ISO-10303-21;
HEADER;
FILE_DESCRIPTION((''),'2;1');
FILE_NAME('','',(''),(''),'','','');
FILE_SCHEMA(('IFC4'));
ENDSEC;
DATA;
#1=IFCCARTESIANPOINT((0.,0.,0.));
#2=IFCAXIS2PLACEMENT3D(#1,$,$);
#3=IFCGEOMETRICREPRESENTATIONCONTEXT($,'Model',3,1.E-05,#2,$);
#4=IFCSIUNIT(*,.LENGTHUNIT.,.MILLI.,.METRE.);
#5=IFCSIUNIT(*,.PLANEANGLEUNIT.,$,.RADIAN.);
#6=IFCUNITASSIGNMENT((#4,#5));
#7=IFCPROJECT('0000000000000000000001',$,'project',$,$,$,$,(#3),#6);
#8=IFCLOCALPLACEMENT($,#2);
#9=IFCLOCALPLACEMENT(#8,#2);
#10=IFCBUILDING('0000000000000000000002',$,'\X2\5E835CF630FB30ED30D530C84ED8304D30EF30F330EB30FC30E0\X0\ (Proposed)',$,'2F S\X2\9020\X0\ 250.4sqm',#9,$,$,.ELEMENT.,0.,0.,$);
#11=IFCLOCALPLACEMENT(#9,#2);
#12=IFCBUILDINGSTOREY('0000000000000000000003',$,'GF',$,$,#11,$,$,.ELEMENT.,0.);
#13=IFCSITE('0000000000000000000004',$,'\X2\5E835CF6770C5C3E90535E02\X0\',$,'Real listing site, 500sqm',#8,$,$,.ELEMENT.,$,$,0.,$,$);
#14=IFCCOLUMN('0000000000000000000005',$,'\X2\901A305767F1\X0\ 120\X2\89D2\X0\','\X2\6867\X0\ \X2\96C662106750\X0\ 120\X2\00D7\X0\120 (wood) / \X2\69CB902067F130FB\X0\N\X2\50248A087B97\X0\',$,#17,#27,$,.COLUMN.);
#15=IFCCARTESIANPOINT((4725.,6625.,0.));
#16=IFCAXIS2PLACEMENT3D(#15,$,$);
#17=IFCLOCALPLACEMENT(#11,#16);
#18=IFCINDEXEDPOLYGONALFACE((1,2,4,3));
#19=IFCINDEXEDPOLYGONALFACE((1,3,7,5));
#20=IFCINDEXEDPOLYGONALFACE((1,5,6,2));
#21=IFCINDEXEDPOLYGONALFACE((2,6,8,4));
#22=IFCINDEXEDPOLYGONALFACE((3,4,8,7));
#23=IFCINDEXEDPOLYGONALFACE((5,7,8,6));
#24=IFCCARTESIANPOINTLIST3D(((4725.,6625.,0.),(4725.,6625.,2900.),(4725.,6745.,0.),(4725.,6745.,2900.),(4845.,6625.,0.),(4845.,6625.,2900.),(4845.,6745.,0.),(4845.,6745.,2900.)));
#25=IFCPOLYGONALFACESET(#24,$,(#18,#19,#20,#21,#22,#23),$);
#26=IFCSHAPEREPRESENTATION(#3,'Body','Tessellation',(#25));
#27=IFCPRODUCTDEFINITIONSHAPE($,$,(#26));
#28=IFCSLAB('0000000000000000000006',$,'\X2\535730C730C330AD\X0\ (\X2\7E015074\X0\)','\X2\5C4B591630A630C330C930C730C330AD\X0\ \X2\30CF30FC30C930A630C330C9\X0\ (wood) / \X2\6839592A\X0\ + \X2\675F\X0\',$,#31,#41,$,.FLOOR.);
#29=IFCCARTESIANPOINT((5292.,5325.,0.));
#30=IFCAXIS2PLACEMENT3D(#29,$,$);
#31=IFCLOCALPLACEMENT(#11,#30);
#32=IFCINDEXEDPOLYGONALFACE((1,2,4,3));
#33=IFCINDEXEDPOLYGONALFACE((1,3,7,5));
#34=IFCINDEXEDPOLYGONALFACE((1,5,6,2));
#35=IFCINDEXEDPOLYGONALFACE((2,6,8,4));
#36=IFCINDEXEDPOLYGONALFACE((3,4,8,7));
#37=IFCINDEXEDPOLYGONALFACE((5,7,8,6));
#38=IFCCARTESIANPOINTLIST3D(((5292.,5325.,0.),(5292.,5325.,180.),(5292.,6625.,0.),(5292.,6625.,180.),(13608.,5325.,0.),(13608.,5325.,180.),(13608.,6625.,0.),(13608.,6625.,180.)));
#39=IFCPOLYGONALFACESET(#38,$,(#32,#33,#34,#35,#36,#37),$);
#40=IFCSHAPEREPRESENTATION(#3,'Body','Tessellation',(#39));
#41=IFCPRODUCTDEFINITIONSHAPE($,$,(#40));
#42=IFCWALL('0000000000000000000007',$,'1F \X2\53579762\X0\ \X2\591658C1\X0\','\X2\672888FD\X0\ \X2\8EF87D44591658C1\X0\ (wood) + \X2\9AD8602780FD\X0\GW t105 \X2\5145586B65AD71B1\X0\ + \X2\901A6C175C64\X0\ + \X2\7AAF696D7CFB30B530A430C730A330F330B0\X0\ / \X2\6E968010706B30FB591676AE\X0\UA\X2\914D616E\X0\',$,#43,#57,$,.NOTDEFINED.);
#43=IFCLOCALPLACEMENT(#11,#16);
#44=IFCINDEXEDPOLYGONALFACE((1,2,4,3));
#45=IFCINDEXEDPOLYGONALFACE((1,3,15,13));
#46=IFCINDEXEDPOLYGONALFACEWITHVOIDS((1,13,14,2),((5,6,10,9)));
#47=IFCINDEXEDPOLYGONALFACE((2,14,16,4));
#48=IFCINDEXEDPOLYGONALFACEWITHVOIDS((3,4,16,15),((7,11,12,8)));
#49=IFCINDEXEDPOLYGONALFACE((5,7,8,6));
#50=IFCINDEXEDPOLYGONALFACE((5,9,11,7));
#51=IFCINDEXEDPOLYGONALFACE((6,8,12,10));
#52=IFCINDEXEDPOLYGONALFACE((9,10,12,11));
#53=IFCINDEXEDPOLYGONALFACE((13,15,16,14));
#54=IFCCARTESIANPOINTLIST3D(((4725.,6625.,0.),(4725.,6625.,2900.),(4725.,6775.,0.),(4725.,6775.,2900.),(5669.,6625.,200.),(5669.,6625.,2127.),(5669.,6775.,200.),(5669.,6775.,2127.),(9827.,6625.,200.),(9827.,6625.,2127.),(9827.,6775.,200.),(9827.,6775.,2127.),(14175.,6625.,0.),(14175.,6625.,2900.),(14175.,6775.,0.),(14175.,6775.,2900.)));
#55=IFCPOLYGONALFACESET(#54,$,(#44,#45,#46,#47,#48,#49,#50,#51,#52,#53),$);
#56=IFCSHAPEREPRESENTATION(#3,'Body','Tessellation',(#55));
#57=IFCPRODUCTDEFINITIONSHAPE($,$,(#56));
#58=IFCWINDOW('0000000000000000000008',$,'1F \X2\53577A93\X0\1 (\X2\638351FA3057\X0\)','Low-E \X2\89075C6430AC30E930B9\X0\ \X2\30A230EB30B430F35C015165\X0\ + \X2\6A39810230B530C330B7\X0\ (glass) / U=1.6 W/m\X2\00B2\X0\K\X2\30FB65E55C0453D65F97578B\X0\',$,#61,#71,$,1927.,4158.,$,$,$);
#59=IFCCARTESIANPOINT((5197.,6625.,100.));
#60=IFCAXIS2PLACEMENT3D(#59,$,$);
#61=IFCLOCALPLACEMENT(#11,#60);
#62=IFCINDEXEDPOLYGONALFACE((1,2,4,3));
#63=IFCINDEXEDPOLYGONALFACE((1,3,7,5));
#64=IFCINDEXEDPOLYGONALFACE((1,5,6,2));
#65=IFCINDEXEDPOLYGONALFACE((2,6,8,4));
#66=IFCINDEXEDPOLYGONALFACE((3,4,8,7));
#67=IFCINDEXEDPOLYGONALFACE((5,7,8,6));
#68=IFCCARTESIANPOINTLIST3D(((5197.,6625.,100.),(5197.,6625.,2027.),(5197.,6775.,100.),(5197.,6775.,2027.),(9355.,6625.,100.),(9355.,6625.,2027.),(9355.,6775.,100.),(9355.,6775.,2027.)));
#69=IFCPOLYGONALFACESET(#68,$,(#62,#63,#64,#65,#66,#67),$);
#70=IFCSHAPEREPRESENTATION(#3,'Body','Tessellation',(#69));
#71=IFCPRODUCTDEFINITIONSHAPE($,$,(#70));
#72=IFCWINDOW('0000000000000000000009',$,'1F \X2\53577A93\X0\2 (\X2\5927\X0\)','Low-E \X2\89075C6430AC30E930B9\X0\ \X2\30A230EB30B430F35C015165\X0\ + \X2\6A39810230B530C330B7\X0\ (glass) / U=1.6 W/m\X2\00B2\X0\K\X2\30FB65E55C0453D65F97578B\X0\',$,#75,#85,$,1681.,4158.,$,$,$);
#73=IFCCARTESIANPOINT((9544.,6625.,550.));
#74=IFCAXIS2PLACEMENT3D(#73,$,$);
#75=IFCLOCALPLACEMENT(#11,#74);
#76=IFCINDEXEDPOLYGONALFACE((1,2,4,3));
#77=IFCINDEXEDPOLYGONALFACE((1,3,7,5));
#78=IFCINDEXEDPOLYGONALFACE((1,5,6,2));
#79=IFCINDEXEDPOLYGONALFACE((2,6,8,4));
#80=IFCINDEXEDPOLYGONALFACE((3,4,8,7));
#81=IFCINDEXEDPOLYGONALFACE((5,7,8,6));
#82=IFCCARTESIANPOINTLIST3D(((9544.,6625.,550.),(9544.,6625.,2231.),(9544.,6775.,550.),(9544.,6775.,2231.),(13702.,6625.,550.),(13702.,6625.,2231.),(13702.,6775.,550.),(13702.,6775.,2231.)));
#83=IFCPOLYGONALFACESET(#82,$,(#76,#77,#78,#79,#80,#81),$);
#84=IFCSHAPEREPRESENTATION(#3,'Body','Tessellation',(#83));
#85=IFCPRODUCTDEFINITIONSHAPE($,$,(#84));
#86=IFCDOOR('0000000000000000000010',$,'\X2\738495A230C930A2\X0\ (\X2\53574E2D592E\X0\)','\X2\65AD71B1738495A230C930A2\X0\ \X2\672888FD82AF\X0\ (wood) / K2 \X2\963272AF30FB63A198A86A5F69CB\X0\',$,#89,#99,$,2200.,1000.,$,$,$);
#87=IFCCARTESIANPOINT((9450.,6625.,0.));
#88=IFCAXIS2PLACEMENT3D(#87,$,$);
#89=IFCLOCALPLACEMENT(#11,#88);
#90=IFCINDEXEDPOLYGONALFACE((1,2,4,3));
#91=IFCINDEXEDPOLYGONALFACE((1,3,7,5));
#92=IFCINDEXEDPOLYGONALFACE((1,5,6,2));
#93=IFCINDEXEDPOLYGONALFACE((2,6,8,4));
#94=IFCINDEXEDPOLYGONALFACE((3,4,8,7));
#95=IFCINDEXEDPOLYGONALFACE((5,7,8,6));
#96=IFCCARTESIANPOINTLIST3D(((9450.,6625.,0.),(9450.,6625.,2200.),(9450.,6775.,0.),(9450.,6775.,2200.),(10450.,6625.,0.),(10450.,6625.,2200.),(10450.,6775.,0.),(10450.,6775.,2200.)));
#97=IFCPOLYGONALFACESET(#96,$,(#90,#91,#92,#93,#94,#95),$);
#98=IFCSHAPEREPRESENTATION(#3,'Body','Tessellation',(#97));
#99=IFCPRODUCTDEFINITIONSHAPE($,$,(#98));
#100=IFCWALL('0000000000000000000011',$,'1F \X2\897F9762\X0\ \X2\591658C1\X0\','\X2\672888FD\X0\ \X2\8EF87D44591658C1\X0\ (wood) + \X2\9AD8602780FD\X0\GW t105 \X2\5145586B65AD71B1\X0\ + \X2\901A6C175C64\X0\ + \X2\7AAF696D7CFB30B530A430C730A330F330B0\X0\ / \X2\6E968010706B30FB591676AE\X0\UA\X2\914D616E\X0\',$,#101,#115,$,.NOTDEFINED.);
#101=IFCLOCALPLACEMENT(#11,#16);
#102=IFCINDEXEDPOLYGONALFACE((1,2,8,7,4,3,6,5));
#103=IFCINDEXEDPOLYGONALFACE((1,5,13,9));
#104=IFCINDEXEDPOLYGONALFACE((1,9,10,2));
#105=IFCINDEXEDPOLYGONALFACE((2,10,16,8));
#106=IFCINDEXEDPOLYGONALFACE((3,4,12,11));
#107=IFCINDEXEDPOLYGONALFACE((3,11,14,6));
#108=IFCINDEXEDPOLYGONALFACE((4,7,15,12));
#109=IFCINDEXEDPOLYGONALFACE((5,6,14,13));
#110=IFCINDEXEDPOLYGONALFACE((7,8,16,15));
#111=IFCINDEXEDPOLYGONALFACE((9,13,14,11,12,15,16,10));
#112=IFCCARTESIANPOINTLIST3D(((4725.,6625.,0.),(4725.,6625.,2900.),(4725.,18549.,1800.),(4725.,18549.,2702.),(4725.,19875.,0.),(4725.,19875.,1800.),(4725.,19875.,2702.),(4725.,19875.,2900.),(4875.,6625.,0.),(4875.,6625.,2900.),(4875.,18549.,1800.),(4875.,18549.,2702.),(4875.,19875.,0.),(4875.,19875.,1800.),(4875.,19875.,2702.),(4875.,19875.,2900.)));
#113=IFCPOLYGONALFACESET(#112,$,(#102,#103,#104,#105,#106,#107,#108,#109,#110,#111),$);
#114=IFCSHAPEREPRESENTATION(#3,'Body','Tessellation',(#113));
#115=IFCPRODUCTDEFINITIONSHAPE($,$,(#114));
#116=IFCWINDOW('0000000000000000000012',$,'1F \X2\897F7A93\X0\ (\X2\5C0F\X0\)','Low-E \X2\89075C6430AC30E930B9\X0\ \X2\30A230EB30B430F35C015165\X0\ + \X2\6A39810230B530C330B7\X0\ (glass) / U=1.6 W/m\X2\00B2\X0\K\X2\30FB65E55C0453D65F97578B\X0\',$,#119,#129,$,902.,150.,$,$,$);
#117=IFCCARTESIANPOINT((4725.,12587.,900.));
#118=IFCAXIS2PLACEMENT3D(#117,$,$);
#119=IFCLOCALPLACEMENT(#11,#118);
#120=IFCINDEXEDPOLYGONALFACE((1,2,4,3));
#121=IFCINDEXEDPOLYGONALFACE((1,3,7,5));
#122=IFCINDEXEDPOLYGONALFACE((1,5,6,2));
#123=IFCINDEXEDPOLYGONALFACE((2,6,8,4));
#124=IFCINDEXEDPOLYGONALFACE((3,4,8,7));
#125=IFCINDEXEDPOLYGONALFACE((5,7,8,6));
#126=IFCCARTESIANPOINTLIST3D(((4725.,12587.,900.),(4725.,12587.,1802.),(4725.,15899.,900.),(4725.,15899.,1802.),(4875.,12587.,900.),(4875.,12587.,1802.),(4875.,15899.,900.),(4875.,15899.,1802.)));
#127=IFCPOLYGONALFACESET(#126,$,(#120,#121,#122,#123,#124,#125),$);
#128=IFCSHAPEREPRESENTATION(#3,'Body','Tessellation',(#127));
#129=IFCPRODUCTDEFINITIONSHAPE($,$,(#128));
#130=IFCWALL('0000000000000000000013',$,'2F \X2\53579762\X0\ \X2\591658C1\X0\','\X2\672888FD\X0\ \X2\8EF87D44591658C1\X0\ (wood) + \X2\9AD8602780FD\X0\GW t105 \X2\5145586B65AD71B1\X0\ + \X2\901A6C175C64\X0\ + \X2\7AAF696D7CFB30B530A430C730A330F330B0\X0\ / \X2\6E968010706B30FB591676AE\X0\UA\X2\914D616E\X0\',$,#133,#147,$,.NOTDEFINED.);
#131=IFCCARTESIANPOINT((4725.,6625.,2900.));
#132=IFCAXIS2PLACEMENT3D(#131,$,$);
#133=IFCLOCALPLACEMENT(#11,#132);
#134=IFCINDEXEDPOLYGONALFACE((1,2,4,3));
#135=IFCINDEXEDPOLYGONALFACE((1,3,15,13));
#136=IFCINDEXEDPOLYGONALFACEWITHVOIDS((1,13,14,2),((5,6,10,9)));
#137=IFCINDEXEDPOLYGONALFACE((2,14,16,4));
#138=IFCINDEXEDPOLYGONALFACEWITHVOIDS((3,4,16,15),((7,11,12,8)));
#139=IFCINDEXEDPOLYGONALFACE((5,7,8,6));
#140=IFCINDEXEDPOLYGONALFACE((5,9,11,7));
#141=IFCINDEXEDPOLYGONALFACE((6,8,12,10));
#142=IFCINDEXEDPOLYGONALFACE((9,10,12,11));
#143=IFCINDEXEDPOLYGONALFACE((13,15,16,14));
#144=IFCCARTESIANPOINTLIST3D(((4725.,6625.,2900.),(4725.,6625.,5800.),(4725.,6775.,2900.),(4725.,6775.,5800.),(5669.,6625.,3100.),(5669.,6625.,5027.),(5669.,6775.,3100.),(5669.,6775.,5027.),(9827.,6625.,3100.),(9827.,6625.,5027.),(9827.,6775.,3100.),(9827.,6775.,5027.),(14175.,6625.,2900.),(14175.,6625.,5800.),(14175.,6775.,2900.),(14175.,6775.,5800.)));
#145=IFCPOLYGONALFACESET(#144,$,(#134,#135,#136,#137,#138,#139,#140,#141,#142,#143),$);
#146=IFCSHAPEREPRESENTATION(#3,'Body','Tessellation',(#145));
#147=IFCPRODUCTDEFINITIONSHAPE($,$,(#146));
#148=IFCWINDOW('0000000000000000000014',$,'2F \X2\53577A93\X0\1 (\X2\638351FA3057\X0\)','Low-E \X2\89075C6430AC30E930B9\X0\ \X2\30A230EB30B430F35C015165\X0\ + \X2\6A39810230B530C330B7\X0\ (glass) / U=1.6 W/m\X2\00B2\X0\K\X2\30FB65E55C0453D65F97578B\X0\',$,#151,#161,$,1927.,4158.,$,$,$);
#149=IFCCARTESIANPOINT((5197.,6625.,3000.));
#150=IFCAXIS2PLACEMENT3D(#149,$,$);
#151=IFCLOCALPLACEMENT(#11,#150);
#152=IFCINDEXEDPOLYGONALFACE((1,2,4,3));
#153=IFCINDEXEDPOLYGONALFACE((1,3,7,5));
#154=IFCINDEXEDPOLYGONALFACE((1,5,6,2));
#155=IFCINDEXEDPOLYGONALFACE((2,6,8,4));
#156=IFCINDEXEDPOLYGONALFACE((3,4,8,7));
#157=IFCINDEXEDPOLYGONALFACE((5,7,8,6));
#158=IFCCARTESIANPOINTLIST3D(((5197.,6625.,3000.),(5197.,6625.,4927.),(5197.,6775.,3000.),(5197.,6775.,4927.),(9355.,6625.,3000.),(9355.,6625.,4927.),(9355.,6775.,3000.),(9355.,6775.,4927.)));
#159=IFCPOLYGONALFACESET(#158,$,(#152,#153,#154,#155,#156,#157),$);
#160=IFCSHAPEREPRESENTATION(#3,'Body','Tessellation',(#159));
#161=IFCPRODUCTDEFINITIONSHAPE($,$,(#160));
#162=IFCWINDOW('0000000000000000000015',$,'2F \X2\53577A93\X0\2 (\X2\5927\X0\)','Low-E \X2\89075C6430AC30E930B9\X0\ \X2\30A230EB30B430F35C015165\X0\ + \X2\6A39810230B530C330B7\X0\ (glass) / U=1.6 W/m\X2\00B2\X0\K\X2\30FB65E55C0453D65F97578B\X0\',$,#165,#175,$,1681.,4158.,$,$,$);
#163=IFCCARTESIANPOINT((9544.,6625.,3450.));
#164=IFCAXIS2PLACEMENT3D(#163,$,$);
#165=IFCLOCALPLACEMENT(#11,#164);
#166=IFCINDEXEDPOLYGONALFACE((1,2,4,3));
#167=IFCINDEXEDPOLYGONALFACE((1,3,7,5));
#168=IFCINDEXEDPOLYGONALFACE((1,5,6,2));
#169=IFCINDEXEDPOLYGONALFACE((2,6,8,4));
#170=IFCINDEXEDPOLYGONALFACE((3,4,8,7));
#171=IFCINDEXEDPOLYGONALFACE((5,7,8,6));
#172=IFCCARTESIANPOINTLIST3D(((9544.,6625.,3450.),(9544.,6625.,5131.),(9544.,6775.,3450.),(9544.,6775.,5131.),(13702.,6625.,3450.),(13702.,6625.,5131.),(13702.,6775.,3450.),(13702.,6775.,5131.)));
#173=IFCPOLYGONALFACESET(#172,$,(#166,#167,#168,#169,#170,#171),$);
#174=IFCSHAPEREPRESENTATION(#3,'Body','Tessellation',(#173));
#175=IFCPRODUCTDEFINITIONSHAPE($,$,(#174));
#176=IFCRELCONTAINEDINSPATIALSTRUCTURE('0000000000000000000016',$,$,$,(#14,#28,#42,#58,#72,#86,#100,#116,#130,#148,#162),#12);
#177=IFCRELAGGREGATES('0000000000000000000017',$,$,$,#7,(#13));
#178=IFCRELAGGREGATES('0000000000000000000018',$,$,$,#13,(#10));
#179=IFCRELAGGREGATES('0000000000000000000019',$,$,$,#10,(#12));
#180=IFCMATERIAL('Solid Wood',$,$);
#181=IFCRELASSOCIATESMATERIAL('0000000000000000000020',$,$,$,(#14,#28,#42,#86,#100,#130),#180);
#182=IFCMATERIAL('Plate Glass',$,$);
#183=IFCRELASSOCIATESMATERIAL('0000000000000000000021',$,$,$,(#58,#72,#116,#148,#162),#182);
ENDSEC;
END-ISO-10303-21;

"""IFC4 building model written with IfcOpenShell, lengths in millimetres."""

from ifc_helpers import new_model, si_unit, frame, frame_2d, origin, place, context, project, spatial, rectangle, extrude, material, element, fill, save


model = new_model("IFC4")

# Units and contexts
model_context = context("Model", 3, precision=1e-05, world=origin())
ifc_project = project(units=[si_unit("LENGTHUNIT", "METRE", prefix="MILLI"), si_unit("PLANEANGLEUNIT", "RADIAN")], contexts=[model_context])

# Site, building, storey
site_placement = place(None, origin())
site = spatial("IfcSite", under=ifc_project, at=site_placement, Name="広島県尾道市", ObjectType="Real listing site, 500sqm", CompositionType="ELEMENT", RefElevation=0.0)
building_placement = place(site_placement, origin())
building = spatial("IfcBuilding", under=site, at=building_placement, Name="広島・ロフト付きワンルーム (Proposed)", ObjectType="2F S造 250.4sqm", CompositionType="ELEMENT", ElevationOfRefHeight=0.0, ElevationOfTerrain=0.0)
storey_placement = place(building_placement, origin())
storey = spatial("IfcBuildingStorey", under=building, at=storey_placement, Name="GF", CompositionType="ELEMENT", Elevation=0.0)

# Column
ifc_material_1 = material(Name="Solid Wood")
column_placement = place(storey_placement, frame((4725.0, 6625.0, 0.0)))
element("IfcColumn", 1, at=column_placement, inside=storey, material=ifc_material_1, Name="通し柱 120角", Description="桧 集成材 120×120 (wood) / 構造柱・N値計算", PredefinedType="COLUMN", context=model_context, shape_type="SweptSolid", body=[
    extrude(rectangle(XDim=120.0, YDim=120.0, at=frame_2d((60.0, 60.0))), frame((4725.0, 6625.0, 0.0)), (0.0, 0.0, 1.0), 2900.0),
])

# Slab
slab_1_placement = place(storey_placement, frame((5292.0, 5325.0, 0.0)))
element("IfcSlab", 2, at=slab_1_placement, inside=storey, material=ifc_material_1, Name="南デッキ (縁側)", Description="屋外ウッドデッキ ハードウッド (wood) / 根太 + 束", PredefinedType="FLOOR", context=model_context, shape_type="SweptSolid", body=[
    extrude(rectangle(XDim=8316.0, YDim=1300.0, at=frame_2d((4158.0, 650.0))), frame((5292.0, 5325.0, 0.0)), (0.0, 0.0, 1.0), 180.0),
])

# Wall, openings, windows, door
wall_1_placement = place(storey_placement, frame((4725.0, 6625.0, 0.0)))
wall_1 = element("IfcWall", 3, at=wall_1_placement, inside=storey, material=ifc_material_1, Name="1F 南面 外壁", Description="木製 軸組外壁 (wood) + 高性能GW t105 充填断熱 + 通気層 + 窯業系サイディング / 準耐火・外皮UA配慮", PredefinedType="NOTDEFINED", context=model_context, shape_type="SweptSolid", body=[
    extrude(rectangle(XDim=9450.0, YDim=150.0, at=frame_2d((4725.0, 75.0))), frame((4725.0, 6625.0, 0.0)), (0.0, 0.0, 1.0), 2900.0),
])
opening_1_placement = place(storey_placement, frame((5197.0, 6625.0, 100.0)))
opening_1 = element("IfcOpeningElement", 4, at=opening_1_placement, cuts=wall_1, PredefinedType="NOTDEFINED", context=model_context, shape_type="SweptSolid", body=[
    extrude(rectangle(XDim=4158.0, YDim=150.0, at=frame_2d((2079.0, 75.0))), frame((5197.0, 6625.0, 100.0)), (0.0, 0.0, 1.0), 1927.0),
])
opening_2_placement = place(storey_placement, frame((9544.0, 6625.0, 550.0)))
opening_2 = element("IfcOpeningElement", 5, at=opening_2_placement, cuts=wall_1, PredefinedType="NOTDEFINED", context=model_context, shape_type="SweptSolid", body=[
    extrude(rectangle(XDim=4158.0, YDim=150.0, at=frame_2d((2079.0, 75.0))), frame((9544.0, 6625.0, 550.0)), (0.0, 0.0, 1.0), 1681.0),
])
opening_3_placement = place(storey_placement, frame((9450.0, 6625.0, 0.0)))
opening_3 = element("IfcOpeningElement", 6, at=opening_3_placement, cuts=wall_1, PredefinedType="NOTDEFINED", context=model_context, shape_type="SweptSolid", body=[
    extrude(rectangle(XDim=1000.0, YDim=150.0, at=frame_2d((500.0, 75.0))), frame((9450.0, 6625.0, 0.0)), (0.0, 0.0, 1.0), 2200.0),
])
ifc_material_2 = material(Name="Plate Glass")
window_1_placement = place(storey_placement, frame((5197.0, 6625.0, 100.0)))
window_1 = element("IfcWindow", 7, at=window_1_placement, inside=storey, material=ifc_material_2, Name="1F 南窓1 (掃出し)", Description="Low-E 複層ガラス アルゴン封入 + 樹脂サッシ (glass) / U=1.6 W/m²K・日射取得型", OverallHeight=1927.0, OverallWidth=4158.0, context=model_context, shape_type="SweptSolid", body=[
    extrude(rectangle(XDim=4158.0, YDim=150.0, at=frame_2d((2079.0, 75.0))), frame((5197.0, 6625.0, 100.0)), (0.0, 0.0, 1.0), 1927.0),
])
fill(opening_1, window_1)
window_2_placement = place(storey_placement, frame((9544.0, 6625.0, 550.0)))
window_2 = element("IfcWindow", 8, at=window_2_placement, inside=storey, material=ifc_material_2, Name="1F 南窓2 (大)", Description="Low-E 複層ガラス アルゴン封入 + 樹脂サッシ (glass) / U=1.6 W/m²K・日射取得型", OverallHeight=1681.0, OverallWidth=4158.0, context=model_context, shape_type="SweptSolid", body=[
    extrude(rectangle(XDim=4158.0, YDim=150.0, at=frame_2d((2079.0, 75.0))), frame((9544.0, 6625.0, 550.0)), (0.0, 0.0, 1.0), 1681.0),
])
fill(opening_2, window_2)
door_placement = place(storey_placement, frame((9450.0, 6625.0, 0.0)))
door = element("IfcDoor", 9, at=door_placement, inside=storey, material=ifc_material_1, Name="玄関ドア (南中央)", Description="断熱玄関ドア 木製芯 (wood) / K2 防犯・採風機構", OverallHeight=2200.0, OverallWidth=1000.0, context=model_context, shape_type="SweptSolid", body=[
    extrude(rectangle(XDim=1000.0, YDim=150.0, at=frame_2d((500.0, 75.0))), frame((9450.0, 6625.0, 0.0)), (0.0, 0.0, 1.0), 2200.0),
])
fill(opening_3, door)

# Wall, opening, window
wall_2_placement = place(storey_placement, frame((4725.0, 6625.0, 0.0)))
wall_2 = element("IfcWall", 10, at=wall_2_placement, inside=storey, material=ifc_material_1, Name="1F 西面 外壁", Description="木製 軸組外壁 (wood) + 高性能GW t105 充填断熱 + 通気層 + 窯業系サイディング / 準耐火・外皮UA配慮", PredefinedType="NOTDEFINED", context=model_context, shape_type="SweptSolid", body=[
    extrude(rectangle(XDim=150.0, YDim=13250.0, at=frame_2d((75.0, 6625.0))), frame((4725.0, 6625.0, 0.0)), (0.0, 0.0, 1.0), 2900.0),
])
opening_4_placement = place(storey_placement, frame((4725.0, 12587.0, 900.0)))
opening_4 = element("IfcOpeningElement", 11, at=opening_4_placement, cuts=wall_2, PredefinedType="NOTDEFINED", context=model_context, shape_type="SweptSolid", body=[
    extrude(rectangle(XDim=150.0, YDim=3312.0, at=frame_2d((75.0, 1656.0))), frame((4725.0, 12587.0, 900.0)), (0.0, 0.0, 1.0), 902.0),
])
window_3_placement = place(storey_placement, frame((4725.0, 12587.0, 900.0)))
window_3 = element("IfcWindow", 12, at=window_3_placement, inside=storey, material=ifc_material_2, Name="1F 西窓 (小)", Description="Low-E 複層ガラス アルゴン封入 + 樹脂サッシ (glass) / U=1.6 W/m²K・日射取得型", OverallHeight=902.0, OverallWidth=150.0, context=model_context, shape_type="SweptSolid", body=[
    extrude(rectangle(XDim=150.0, YDim=3312.0, at=frame_2d((75.0, 1656.0))), frame((4725.0, 12587.0, 900.0)), (0.0, 0.0, 1.0), 902.0),
])
fill(opening_4, window_3)

# Wall, openings, windows
wall_3_placement = place(storey_placement, frame((4725.0, 6625.0, 2900.0)))
wall_3 = element("IfcWall", 13, at=wall_3_placement, inside=storey, material=ifc_material_1, Name="2F 南面 外壁", Description="木製 軸組外壁 (wood) + 高性能GW t105 充填断熱 + 通気層 + 窯業系サイディング / 準耐火・外皮UA配慮", PredefinedType="NOTDEFINED", context=model_context, shape_type="SweptSolid", body=[
    extrude(rectangle(XDim=9450.0, YDim=150.0, at=frame_2d((4725.0, 75.0))), frame((4725.0, 6625.0, 2900.0)), (0.0, 0.0, 1.0), 2900.0),
])
opening_5_placement = place(storey_placement, frame((5197.0, 6625.0, 3000.0)))
opening_5 = element("IfcOpeningElement", 14, at=opening_5_placement, cuts=wall_3, PredefinedType="NOTDEFINED", context=model_context, shape_type="SweptSolid", body=[
    extrude(rectangle(XDim=4158.0, YDim=150.0, at=frame_2d((2079.0, 75.0))), frame((5197.0, 6625.0, 3000.0)), (0.0, 0.0, 1.0), 1927.0),
])
opening_6_placement = place(storey_placement, frame((9544.0, 6625.0, 3450.0)))
opening_6 = element("IfcOpeningElement", 15, at=opening_6_placement, cuts=wall_3, PredefinedType="NOTDEFINED", context=model_context, shape_type="SweptSolid", body=[
    extrude(rectangle(XDim=4158.0, YDim=150.0, at=frame_2d((2079.0, 75.0))), frame((9544.0, 6625.0, 3450.0)), (0.0, 0.0, 1.0), 1681.0),
])
window_4_placement = place(storey_placement, frame((5197.0, 6625.0, 3000.0)))
window_4 = element("IfcWindow", 16, at=window_4_placement, inside=storey, material=ifc_material_2, Name="2F 南窓1 (掃出し)", Description="Low-E 複層ガラス アルゴン封入 + 樹脂サッシ (glass) / U=1.6 W/m²K・日射取得型", OverallHeight=1927.0, OverallWidth=4158.0, context=model_context, shape_type="SweptSolid", body=[
    extrude(rectangle(XDim=4158.0, YDim=150.0, at=frame_2d((2079.0, 75.0))), frame((5197.0, 6625.0, 3000.0)), (0.0, 0.0, 1.0), 1927.0),
])
fill(opening_5, window_4)
window_5_placement = place(storey_placement, frame((9544.0, 6625.0, 3450.0)))
window_5 = element("IfcWindow", 17, at=window_5_placement, inside=storey, material=ifc_material_2, Name="2F 南窓2 (大)", Description="Low-E 複層ガラス アルゴン封入 + 樹脂サッシ (glass) / U=1.6 W/m²K・日射取得型", OverallHeight=1681.0, OverallWidth=4158.0, context=model_context, shape_type="SweptSolid", body=[
    extrude(rectangle(XDim=4158.0, YDim=150.0, at=frame_2d((2079.0, 75.0))), frame((9544.0, 6625.0, 3450.0)), (0.0, 0.0, 1.0), 1681.0),
])
fill(opening_6, window_5)

save(model, "model.ifc")
